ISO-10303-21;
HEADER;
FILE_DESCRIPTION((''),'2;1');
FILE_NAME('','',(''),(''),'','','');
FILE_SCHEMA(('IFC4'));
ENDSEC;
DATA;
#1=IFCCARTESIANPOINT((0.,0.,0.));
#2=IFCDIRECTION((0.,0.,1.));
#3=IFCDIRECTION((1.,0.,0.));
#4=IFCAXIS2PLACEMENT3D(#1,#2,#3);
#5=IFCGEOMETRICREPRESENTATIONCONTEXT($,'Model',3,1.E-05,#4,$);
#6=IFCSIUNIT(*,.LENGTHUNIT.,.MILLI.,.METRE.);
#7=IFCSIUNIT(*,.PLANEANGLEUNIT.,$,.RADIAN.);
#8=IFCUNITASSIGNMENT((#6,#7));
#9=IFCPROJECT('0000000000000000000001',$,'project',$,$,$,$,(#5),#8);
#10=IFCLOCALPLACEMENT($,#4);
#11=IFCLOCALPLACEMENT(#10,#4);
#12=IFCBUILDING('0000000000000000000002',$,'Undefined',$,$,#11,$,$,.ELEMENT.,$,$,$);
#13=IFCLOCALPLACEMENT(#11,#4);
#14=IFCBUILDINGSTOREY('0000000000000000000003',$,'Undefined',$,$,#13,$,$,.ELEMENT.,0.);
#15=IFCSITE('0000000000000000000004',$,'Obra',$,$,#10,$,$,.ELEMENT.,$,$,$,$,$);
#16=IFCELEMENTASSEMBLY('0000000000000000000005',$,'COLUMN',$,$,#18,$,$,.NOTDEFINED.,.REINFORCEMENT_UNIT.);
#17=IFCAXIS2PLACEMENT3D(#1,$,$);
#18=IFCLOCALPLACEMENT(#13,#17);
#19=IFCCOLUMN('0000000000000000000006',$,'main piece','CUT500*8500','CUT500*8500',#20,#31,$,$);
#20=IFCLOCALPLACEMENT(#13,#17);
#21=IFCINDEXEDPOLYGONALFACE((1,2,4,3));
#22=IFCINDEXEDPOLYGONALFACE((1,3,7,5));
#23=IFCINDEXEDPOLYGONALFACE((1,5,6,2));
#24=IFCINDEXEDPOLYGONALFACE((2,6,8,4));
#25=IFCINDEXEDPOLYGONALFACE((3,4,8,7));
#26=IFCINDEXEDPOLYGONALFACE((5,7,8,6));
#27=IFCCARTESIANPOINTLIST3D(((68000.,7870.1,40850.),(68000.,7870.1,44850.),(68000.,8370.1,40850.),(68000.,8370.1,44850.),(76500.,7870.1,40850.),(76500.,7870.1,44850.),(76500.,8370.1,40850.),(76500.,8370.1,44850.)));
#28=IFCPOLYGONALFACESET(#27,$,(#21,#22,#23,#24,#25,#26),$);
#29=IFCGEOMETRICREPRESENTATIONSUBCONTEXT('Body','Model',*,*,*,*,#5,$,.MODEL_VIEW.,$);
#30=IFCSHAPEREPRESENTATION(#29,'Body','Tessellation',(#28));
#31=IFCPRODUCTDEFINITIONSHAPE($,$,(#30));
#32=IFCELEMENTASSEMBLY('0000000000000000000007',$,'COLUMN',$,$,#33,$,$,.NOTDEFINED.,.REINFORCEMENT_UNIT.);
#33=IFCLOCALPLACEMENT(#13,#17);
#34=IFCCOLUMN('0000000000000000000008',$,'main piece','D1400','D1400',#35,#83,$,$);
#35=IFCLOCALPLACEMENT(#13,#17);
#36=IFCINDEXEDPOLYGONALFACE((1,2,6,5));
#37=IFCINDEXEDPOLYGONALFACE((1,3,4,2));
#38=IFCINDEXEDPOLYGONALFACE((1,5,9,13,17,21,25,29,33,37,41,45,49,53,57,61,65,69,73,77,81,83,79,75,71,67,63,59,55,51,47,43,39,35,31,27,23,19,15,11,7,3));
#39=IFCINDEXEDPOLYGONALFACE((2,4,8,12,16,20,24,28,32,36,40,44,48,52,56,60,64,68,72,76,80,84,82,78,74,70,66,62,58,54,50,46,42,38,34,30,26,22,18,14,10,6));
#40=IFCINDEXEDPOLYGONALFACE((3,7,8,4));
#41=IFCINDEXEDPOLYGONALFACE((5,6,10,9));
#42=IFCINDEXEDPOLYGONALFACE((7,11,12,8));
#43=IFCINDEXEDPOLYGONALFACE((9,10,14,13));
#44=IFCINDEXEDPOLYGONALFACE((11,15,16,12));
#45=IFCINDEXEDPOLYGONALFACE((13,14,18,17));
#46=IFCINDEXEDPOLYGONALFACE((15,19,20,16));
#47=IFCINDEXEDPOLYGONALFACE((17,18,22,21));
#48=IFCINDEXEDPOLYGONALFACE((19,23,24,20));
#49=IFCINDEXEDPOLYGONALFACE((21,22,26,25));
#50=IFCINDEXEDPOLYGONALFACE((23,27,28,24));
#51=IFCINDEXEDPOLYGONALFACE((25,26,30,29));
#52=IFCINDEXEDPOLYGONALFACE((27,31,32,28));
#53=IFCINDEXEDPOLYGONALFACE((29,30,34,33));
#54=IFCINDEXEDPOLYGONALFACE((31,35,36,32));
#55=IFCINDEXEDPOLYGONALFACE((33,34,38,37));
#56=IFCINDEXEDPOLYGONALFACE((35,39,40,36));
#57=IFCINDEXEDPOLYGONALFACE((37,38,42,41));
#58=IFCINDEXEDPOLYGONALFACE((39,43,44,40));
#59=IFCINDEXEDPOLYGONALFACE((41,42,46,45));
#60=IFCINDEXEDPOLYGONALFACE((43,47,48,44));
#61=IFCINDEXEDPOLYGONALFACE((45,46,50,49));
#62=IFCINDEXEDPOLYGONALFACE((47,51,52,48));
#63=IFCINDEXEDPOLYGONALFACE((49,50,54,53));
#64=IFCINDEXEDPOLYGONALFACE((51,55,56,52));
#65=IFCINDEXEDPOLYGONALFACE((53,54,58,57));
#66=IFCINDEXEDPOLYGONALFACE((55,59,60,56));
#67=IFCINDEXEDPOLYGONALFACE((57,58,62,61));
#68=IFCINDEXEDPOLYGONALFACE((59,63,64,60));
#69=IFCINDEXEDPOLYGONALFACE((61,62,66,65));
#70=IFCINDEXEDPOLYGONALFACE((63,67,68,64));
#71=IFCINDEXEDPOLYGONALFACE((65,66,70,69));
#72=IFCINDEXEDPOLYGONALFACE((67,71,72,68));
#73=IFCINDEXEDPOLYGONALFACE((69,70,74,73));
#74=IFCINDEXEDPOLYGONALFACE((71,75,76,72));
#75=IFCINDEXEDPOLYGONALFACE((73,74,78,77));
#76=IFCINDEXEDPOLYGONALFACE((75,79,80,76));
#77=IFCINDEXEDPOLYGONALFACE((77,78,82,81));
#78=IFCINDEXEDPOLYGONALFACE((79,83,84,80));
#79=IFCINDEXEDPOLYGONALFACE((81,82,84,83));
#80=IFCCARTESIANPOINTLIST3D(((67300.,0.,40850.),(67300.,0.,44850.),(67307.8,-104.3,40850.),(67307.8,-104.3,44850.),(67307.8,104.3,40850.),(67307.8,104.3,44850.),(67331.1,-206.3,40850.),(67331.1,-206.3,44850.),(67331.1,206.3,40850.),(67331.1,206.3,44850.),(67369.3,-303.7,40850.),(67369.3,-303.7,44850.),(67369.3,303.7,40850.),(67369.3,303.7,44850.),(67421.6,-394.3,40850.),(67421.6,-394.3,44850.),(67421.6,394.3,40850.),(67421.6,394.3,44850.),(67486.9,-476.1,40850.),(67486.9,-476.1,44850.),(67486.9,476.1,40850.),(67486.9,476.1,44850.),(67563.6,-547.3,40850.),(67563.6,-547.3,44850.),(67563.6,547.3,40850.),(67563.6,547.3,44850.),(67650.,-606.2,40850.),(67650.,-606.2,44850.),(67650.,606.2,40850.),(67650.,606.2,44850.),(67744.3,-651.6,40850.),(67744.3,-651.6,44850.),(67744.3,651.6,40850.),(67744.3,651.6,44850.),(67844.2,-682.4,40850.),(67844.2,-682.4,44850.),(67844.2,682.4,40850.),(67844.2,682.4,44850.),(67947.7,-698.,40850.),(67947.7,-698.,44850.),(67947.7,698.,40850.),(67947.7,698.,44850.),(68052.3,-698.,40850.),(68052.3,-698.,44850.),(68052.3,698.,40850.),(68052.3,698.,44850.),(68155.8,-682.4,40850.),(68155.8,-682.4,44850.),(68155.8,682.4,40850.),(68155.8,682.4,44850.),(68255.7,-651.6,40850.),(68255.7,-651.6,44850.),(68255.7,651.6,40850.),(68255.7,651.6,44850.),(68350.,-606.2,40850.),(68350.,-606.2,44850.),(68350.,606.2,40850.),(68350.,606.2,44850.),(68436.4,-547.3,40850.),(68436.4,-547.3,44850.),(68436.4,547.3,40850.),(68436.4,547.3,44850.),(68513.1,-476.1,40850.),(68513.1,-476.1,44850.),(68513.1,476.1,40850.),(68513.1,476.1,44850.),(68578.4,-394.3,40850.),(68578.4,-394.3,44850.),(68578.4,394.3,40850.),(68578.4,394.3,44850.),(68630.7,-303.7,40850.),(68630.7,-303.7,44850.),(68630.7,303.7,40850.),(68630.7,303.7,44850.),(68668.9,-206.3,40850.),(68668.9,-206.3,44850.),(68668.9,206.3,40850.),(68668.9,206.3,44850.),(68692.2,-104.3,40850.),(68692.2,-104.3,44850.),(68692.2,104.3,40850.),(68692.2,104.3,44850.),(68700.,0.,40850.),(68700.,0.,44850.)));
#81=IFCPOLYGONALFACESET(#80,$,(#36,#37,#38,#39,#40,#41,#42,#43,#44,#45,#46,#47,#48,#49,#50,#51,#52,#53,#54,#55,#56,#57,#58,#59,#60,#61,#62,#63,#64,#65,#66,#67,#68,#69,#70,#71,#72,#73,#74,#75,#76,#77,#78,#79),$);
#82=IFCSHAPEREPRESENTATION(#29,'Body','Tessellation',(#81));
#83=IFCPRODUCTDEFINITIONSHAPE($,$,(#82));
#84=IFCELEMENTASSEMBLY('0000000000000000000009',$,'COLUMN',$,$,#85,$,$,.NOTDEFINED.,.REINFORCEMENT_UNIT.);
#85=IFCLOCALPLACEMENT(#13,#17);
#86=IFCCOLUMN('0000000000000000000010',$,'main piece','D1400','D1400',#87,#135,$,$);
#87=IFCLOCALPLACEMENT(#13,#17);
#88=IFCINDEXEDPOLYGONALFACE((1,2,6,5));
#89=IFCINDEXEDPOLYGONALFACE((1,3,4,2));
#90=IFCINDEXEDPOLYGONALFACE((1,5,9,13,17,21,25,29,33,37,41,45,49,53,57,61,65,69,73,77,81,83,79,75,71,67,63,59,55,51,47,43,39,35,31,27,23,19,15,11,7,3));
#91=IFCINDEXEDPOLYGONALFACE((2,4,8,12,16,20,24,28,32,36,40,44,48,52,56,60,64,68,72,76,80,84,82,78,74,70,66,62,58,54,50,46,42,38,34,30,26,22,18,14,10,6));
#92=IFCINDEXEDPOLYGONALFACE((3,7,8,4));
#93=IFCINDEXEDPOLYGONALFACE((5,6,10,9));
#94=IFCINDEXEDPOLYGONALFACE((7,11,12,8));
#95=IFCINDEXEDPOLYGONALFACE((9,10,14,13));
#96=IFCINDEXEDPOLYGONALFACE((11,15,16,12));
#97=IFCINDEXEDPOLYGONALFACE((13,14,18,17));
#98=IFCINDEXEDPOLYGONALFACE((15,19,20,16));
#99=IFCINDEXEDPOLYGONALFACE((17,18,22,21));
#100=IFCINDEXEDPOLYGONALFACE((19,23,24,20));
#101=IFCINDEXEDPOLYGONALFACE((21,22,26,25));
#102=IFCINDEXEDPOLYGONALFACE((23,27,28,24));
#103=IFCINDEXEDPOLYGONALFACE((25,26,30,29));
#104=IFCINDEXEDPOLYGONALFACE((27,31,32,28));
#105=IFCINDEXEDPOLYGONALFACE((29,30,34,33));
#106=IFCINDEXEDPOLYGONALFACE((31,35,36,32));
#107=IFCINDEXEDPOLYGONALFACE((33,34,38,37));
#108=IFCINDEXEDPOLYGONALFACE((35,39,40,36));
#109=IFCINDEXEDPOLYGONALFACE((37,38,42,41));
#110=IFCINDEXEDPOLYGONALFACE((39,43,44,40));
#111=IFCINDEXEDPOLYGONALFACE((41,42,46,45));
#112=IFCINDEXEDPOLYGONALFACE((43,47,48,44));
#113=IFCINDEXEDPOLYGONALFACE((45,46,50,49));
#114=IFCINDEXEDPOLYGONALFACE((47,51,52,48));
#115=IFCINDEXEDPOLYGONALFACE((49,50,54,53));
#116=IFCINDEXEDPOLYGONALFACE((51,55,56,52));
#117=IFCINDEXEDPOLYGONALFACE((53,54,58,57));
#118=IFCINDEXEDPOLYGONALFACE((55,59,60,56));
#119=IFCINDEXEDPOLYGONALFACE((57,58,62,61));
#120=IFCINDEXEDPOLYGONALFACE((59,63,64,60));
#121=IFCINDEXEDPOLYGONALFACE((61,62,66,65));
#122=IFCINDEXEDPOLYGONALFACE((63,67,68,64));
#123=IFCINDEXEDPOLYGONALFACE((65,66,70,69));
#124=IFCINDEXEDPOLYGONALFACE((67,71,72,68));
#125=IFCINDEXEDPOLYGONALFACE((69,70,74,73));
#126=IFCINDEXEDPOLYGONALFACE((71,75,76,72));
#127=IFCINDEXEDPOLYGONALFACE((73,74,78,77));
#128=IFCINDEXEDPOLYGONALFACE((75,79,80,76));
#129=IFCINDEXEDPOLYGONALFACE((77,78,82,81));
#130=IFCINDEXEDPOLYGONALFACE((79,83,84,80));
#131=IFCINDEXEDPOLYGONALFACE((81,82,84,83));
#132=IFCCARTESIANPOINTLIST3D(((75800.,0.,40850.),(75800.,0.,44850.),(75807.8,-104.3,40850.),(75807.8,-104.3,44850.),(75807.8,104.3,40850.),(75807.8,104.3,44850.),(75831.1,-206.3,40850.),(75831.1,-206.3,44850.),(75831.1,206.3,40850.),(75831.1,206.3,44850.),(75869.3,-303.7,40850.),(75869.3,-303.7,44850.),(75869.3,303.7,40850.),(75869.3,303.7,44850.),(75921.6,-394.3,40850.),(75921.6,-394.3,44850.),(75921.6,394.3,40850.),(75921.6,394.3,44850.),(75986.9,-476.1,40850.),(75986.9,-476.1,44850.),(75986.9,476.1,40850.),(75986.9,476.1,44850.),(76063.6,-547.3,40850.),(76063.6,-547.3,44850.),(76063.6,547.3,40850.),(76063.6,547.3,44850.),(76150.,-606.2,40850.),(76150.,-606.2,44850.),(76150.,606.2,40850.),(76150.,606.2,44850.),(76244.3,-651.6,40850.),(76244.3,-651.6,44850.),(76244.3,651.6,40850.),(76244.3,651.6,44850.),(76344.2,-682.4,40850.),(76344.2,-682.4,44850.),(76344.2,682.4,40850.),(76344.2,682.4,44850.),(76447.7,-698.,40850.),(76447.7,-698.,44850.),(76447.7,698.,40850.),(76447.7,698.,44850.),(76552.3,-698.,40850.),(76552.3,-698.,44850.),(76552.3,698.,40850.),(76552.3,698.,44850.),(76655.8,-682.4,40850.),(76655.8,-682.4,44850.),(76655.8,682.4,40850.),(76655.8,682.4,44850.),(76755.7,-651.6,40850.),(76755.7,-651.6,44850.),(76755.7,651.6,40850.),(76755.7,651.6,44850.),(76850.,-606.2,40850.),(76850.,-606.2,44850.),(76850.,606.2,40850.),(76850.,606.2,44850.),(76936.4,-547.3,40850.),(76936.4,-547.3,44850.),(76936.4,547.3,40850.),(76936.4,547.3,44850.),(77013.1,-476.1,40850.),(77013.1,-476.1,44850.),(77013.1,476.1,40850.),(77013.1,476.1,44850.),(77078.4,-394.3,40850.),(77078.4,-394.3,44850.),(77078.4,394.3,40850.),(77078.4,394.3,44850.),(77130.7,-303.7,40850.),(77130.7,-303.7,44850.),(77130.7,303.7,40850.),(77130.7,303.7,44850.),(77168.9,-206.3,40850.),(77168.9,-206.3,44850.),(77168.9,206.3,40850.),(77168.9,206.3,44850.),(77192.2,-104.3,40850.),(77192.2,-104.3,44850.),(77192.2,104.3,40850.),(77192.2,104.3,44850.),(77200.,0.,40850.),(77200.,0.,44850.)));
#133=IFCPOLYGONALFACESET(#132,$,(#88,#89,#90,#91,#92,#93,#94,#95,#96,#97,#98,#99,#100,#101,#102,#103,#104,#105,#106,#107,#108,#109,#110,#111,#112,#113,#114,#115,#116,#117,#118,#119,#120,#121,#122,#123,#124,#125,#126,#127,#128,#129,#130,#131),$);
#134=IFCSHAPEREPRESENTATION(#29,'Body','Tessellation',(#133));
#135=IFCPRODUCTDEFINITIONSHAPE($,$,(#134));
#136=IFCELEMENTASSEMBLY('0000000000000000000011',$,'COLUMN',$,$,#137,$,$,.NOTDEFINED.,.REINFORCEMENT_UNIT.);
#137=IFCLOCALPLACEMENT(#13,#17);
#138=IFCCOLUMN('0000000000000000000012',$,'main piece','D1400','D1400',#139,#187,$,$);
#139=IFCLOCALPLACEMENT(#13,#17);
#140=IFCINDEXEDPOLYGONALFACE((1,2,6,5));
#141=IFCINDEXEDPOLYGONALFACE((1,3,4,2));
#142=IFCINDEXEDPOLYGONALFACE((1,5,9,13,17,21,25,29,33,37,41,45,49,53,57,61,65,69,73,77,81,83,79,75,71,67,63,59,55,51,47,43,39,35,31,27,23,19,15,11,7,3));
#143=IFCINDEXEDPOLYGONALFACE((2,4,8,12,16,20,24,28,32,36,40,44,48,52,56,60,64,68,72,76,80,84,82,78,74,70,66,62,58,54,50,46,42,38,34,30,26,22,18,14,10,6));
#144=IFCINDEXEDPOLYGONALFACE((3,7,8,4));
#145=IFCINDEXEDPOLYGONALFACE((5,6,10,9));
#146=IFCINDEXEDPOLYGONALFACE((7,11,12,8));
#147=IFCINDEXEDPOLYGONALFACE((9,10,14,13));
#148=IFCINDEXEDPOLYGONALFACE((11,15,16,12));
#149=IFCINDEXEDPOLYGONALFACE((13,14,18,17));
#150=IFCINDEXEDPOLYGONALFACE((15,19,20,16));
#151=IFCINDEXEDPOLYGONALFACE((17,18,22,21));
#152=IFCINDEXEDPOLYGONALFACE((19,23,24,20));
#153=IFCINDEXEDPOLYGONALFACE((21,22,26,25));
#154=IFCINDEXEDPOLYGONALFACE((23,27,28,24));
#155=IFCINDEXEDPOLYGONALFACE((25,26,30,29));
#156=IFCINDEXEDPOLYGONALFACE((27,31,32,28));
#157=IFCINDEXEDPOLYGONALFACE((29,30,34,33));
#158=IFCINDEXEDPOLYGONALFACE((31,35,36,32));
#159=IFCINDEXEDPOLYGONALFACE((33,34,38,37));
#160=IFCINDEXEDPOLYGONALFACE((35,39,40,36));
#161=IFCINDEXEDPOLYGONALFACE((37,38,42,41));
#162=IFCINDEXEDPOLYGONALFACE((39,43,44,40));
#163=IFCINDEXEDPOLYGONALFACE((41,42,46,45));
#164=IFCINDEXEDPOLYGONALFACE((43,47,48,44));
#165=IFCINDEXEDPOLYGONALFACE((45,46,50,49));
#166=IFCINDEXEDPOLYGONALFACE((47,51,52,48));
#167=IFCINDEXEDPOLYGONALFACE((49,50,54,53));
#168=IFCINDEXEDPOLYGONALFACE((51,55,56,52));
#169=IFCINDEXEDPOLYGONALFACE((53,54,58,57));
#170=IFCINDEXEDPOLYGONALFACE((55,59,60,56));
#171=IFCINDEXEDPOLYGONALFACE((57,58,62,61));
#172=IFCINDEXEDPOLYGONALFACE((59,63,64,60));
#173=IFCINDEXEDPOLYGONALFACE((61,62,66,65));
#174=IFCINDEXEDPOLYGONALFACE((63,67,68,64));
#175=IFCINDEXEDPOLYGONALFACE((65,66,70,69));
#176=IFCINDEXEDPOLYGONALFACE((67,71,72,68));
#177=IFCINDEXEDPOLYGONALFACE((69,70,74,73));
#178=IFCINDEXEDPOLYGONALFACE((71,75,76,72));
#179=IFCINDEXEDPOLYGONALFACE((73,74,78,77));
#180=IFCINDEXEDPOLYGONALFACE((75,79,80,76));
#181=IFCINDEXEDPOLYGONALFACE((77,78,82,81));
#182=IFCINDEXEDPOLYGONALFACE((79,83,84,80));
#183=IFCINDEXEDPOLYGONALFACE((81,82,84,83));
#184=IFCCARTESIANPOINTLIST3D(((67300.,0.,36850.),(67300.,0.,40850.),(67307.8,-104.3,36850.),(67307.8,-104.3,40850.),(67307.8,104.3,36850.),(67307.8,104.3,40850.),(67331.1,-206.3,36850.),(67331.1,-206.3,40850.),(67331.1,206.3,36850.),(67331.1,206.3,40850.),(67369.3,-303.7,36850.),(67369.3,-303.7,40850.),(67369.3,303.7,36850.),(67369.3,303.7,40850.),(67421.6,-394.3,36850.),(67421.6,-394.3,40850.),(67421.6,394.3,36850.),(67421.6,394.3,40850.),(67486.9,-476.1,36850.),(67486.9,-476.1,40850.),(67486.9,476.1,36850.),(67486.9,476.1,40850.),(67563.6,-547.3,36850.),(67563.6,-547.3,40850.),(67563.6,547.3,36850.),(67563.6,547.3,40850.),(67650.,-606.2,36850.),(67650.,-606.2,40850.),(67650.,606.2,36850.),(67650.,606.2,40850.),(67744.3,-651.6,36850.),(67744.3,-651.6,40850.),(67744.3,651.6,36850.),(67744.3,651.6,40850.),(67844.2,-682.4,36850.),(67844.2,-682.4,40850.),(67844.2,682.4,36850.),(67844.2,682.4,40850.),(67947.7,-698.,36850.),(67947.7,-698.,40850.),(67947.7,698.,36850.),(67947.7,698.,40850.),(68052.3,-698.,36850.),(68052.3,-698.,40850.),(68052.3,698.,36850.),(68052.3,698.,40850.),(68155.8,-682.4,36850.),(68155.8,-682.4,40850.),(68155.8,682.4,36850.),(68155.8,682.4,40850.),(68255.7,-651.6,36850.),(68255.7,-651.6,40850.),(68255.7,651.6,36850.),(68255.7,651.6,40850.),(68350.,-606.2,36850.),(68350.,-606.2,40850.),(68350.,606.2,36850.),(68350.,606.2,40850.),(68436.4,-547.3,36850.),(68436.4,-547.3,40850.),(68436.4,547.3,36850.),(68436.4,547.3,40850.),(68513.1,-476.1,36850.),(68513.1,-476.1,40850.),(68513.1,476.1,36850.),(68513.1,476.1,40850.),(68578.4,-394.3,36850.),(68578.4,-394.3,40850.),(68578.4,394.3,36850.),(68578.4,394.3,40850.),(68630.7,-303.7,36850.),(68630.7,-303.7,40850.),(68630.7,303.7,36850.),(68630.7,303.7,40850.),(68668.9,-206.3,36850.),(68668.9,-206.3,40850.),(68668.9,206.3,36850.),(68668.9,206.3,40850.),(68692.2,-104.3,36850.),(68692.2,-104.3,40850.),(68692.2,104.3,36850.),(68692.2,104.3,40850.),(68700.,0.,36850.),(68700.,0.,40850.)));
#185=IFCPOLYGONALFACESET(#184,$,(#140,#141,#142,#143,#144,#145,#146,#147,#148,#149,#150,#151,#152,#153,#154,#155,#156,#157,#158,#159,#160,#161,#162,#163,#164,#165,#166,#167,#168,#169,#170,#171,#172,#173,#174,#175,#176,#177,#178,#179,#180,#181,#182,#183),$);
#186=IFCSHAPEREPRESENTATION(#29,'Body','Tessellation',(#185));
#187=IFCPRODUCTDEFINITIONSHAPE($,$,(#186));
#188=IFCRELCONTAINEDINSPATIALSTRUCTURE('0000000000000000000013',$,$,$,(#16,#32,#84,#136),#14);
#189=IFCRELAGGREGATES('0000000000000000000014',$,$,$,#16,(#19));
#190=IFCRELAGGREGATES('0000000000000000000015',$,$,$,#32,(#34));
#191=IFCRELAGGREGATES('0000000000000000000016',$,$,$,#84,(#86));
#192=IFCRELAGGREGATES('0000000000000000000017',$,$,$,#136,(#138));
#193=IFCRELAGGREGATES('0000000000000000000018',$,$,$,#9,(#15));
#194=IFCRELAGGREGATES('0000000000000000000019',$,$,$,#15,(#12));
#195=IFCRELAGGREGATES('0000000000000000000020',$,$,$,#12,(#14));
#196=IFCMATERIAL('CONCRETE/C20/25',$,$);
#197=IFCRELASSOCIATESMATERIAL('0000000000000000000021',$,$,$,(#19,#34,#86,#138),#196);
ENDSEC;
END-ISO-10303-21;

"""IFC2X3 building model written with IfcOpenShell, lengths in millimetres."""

from ifc_helpers import new_model, si_unit, frame, origin_with_axes, origin_2d_with_axis, place, context, subcontext, project, spatial, rectangle, circle, extrude, material, element, aggregate, save


model = new_model("IFC2X3")

# Units and contexts
model_context = context("Model", 3, precision=1e-05, world=origin_with_axes())
body_context = subcontext(model_context, "Body", "Model", "MODEL_VIEW")
ifc_project = project(units=[si_unit("LENGTHUNIT", "METRE", prefix="MILLI"), si_unit("PLANEANGLEUNIT", "RADIAN")], contexts=[model_context])

# Site, building, storey
site_placement = place(None, origin_with_axes())
site = spatial("IfcSite", under=ifc_project, at=site_placement, Name="Obra", CompositionType="ELEMENT")
building_placement = place(site_placement, origin_with_axes())
building = spatial("IfcBuilding", under=site, at=building_placement, Name="Undefined", CompositionType="ELEMENT")
storey_placement = place(building_placement, origin_with_axes())
storey = spatial("IfcBuildingStorey", under=building, at=storey_placement, Name="Undefined", CompositionType="ELEMENT", Elevation=0.0)

# Element assemblies, columns
assembly_1_placement = place(storey_placement, origin_with_axes())
assembly_1 = element("IfcElementAssembly", 1, at=assembly_1_placement, inside=storey, Name="COLUMN", AssemblyPlace="NOTDEFINED", PredefinedType="REINFORCEMENT_UNIT")
ifc_material_1 = material(Name="CONCRETE/C20/25")
column_1_placement = place(assembly_1_placement, frame((72250.0, 8120.1, 40850.0), z_axis=(0.0, 0.0, 1.0), x_axis=(-1.0, 0.0, 0.0)))
column_1 = element("IfcColumn", 2, at=column_1_placement, material=ifc_material_1, Name="main piece", Description="CUT500*8500", ObjectType="CUT500*8500", context=body_context, shape_type="SweptSolid", body=[
    extrude(rectangle(XDim=500.0, YDim=8500.0, at=origin_2d_with_axis()), frame((0.0, 0.0, 4000.0), z_axis=(0.0, 0.0, -1.0), x_axis=(0.0, 1.0, 0.0)), (0.0, 0.0, 1.0), 4000.0),
])
aggregate(assembly_1, [column_1])
assembly_2_placement = place(storey_placement, origin_with_axes())
assembly_2 = element("IfcElementAssembly", 3, at=assembly_2_placement, inside=storey, Name="COLUMN", AssemblyPlace="NOTDEFINED", PredefinedType="REINFORCEMENT_UNIT")
column_2_placement = place(assembly_2_placement, frame((68000.0, 0.0, 40850.0), z_axis=(0.0, 0.0, 1.0), x_axis=(0.0, 1.0, 0.0)))
column_2 = element("IfcColumn", 4, at=column_2_placement, material=ifc_material_1, Name="main piece", Description="D1400", ObjectType="D1400", context=body_context, shape_type="SweptSolid", body=[
    extrude(circle(Radius=700.0, at=origin_2d_with_axis()), frame((0.0, 0.0, 4000.0), z_axis=(0.0, 0.0, -1.0), x_axis=(0.0, 1.0, 0.0)), (0.0, 0.0, 1.0), 4000.0),
])
aggregate(assembly_2, [column_2])
assembly_3_placement = place(storey_placement, origin_with_axes())
assembly_3 = element("IfcElementAssembly", 5, at=assembly_3_placement, inside=storey, Name="COLUMN", AssemblyPlace="NOTDEFINED", PredefinedType="REINFORCEMENT_UNIT")
column_3_placement = place(assembly_3_placement, frame((76500.0, 0.0, 40850.0), z_axis=(0.0, 0.0, 1.0), x_axis=(0.0, 1.0, 0.0)))
column_3 = element("IfcColumn", 6, at=column_3_placement, material=ifc_material_1, Name="main piece", Description="D1400", ObjectType="D1400", context=body_context, shape_type="SweptSolid", body=[
    extrude(circle(Radius=700.0, at=origin_2d_with_axis()), frame((0.0, 0.0, 4000.0), z_axis=(0.0, 0.0, -1.0), x_axis=(0.0, 1.0, 0.0)), (0.0, 0.0, 1.0), 4000.0),
])
aggregate(assembly_3, [column_3])
assembly_4_placement = place(storey_placement, origin_with_axes())
assembly_4 = element("IfcElementAssembly", 7, at=assembly_4_placement, inside=storey, Name="COLUMN", AssemblyPlace="NOTDEFINED", PredefinedType="REINFORCEMENT_UNIT")
column_4_placement = place(assembly_4_placement, frame((68000.0, 0.0, 36850.0), z_axis=(0.0, 0.0, 1.0), x_axis=(0.0, 1.0, 0.0)))
column_4 = element("IfcColumn", 8, at=column_4_placement, material=ifc_material_1, Name="main piece", Description="D1400", ObjectType="D1400", context=body_context, shape_type="SweptSolid", body=[
    extrude(circle(Radius=700.0, at=origin_2d_with_axis()), frame((0.0, 0.0, 4000.0), z_axis=(0.0, 0.0, -1.0), x_axis=(0.0, 1.0, 0.0)), (0.0, 0.0, 1.0), 4000.0),
])
aggregate(assembly_4, [column_4])

save(model, "model.ifc")
